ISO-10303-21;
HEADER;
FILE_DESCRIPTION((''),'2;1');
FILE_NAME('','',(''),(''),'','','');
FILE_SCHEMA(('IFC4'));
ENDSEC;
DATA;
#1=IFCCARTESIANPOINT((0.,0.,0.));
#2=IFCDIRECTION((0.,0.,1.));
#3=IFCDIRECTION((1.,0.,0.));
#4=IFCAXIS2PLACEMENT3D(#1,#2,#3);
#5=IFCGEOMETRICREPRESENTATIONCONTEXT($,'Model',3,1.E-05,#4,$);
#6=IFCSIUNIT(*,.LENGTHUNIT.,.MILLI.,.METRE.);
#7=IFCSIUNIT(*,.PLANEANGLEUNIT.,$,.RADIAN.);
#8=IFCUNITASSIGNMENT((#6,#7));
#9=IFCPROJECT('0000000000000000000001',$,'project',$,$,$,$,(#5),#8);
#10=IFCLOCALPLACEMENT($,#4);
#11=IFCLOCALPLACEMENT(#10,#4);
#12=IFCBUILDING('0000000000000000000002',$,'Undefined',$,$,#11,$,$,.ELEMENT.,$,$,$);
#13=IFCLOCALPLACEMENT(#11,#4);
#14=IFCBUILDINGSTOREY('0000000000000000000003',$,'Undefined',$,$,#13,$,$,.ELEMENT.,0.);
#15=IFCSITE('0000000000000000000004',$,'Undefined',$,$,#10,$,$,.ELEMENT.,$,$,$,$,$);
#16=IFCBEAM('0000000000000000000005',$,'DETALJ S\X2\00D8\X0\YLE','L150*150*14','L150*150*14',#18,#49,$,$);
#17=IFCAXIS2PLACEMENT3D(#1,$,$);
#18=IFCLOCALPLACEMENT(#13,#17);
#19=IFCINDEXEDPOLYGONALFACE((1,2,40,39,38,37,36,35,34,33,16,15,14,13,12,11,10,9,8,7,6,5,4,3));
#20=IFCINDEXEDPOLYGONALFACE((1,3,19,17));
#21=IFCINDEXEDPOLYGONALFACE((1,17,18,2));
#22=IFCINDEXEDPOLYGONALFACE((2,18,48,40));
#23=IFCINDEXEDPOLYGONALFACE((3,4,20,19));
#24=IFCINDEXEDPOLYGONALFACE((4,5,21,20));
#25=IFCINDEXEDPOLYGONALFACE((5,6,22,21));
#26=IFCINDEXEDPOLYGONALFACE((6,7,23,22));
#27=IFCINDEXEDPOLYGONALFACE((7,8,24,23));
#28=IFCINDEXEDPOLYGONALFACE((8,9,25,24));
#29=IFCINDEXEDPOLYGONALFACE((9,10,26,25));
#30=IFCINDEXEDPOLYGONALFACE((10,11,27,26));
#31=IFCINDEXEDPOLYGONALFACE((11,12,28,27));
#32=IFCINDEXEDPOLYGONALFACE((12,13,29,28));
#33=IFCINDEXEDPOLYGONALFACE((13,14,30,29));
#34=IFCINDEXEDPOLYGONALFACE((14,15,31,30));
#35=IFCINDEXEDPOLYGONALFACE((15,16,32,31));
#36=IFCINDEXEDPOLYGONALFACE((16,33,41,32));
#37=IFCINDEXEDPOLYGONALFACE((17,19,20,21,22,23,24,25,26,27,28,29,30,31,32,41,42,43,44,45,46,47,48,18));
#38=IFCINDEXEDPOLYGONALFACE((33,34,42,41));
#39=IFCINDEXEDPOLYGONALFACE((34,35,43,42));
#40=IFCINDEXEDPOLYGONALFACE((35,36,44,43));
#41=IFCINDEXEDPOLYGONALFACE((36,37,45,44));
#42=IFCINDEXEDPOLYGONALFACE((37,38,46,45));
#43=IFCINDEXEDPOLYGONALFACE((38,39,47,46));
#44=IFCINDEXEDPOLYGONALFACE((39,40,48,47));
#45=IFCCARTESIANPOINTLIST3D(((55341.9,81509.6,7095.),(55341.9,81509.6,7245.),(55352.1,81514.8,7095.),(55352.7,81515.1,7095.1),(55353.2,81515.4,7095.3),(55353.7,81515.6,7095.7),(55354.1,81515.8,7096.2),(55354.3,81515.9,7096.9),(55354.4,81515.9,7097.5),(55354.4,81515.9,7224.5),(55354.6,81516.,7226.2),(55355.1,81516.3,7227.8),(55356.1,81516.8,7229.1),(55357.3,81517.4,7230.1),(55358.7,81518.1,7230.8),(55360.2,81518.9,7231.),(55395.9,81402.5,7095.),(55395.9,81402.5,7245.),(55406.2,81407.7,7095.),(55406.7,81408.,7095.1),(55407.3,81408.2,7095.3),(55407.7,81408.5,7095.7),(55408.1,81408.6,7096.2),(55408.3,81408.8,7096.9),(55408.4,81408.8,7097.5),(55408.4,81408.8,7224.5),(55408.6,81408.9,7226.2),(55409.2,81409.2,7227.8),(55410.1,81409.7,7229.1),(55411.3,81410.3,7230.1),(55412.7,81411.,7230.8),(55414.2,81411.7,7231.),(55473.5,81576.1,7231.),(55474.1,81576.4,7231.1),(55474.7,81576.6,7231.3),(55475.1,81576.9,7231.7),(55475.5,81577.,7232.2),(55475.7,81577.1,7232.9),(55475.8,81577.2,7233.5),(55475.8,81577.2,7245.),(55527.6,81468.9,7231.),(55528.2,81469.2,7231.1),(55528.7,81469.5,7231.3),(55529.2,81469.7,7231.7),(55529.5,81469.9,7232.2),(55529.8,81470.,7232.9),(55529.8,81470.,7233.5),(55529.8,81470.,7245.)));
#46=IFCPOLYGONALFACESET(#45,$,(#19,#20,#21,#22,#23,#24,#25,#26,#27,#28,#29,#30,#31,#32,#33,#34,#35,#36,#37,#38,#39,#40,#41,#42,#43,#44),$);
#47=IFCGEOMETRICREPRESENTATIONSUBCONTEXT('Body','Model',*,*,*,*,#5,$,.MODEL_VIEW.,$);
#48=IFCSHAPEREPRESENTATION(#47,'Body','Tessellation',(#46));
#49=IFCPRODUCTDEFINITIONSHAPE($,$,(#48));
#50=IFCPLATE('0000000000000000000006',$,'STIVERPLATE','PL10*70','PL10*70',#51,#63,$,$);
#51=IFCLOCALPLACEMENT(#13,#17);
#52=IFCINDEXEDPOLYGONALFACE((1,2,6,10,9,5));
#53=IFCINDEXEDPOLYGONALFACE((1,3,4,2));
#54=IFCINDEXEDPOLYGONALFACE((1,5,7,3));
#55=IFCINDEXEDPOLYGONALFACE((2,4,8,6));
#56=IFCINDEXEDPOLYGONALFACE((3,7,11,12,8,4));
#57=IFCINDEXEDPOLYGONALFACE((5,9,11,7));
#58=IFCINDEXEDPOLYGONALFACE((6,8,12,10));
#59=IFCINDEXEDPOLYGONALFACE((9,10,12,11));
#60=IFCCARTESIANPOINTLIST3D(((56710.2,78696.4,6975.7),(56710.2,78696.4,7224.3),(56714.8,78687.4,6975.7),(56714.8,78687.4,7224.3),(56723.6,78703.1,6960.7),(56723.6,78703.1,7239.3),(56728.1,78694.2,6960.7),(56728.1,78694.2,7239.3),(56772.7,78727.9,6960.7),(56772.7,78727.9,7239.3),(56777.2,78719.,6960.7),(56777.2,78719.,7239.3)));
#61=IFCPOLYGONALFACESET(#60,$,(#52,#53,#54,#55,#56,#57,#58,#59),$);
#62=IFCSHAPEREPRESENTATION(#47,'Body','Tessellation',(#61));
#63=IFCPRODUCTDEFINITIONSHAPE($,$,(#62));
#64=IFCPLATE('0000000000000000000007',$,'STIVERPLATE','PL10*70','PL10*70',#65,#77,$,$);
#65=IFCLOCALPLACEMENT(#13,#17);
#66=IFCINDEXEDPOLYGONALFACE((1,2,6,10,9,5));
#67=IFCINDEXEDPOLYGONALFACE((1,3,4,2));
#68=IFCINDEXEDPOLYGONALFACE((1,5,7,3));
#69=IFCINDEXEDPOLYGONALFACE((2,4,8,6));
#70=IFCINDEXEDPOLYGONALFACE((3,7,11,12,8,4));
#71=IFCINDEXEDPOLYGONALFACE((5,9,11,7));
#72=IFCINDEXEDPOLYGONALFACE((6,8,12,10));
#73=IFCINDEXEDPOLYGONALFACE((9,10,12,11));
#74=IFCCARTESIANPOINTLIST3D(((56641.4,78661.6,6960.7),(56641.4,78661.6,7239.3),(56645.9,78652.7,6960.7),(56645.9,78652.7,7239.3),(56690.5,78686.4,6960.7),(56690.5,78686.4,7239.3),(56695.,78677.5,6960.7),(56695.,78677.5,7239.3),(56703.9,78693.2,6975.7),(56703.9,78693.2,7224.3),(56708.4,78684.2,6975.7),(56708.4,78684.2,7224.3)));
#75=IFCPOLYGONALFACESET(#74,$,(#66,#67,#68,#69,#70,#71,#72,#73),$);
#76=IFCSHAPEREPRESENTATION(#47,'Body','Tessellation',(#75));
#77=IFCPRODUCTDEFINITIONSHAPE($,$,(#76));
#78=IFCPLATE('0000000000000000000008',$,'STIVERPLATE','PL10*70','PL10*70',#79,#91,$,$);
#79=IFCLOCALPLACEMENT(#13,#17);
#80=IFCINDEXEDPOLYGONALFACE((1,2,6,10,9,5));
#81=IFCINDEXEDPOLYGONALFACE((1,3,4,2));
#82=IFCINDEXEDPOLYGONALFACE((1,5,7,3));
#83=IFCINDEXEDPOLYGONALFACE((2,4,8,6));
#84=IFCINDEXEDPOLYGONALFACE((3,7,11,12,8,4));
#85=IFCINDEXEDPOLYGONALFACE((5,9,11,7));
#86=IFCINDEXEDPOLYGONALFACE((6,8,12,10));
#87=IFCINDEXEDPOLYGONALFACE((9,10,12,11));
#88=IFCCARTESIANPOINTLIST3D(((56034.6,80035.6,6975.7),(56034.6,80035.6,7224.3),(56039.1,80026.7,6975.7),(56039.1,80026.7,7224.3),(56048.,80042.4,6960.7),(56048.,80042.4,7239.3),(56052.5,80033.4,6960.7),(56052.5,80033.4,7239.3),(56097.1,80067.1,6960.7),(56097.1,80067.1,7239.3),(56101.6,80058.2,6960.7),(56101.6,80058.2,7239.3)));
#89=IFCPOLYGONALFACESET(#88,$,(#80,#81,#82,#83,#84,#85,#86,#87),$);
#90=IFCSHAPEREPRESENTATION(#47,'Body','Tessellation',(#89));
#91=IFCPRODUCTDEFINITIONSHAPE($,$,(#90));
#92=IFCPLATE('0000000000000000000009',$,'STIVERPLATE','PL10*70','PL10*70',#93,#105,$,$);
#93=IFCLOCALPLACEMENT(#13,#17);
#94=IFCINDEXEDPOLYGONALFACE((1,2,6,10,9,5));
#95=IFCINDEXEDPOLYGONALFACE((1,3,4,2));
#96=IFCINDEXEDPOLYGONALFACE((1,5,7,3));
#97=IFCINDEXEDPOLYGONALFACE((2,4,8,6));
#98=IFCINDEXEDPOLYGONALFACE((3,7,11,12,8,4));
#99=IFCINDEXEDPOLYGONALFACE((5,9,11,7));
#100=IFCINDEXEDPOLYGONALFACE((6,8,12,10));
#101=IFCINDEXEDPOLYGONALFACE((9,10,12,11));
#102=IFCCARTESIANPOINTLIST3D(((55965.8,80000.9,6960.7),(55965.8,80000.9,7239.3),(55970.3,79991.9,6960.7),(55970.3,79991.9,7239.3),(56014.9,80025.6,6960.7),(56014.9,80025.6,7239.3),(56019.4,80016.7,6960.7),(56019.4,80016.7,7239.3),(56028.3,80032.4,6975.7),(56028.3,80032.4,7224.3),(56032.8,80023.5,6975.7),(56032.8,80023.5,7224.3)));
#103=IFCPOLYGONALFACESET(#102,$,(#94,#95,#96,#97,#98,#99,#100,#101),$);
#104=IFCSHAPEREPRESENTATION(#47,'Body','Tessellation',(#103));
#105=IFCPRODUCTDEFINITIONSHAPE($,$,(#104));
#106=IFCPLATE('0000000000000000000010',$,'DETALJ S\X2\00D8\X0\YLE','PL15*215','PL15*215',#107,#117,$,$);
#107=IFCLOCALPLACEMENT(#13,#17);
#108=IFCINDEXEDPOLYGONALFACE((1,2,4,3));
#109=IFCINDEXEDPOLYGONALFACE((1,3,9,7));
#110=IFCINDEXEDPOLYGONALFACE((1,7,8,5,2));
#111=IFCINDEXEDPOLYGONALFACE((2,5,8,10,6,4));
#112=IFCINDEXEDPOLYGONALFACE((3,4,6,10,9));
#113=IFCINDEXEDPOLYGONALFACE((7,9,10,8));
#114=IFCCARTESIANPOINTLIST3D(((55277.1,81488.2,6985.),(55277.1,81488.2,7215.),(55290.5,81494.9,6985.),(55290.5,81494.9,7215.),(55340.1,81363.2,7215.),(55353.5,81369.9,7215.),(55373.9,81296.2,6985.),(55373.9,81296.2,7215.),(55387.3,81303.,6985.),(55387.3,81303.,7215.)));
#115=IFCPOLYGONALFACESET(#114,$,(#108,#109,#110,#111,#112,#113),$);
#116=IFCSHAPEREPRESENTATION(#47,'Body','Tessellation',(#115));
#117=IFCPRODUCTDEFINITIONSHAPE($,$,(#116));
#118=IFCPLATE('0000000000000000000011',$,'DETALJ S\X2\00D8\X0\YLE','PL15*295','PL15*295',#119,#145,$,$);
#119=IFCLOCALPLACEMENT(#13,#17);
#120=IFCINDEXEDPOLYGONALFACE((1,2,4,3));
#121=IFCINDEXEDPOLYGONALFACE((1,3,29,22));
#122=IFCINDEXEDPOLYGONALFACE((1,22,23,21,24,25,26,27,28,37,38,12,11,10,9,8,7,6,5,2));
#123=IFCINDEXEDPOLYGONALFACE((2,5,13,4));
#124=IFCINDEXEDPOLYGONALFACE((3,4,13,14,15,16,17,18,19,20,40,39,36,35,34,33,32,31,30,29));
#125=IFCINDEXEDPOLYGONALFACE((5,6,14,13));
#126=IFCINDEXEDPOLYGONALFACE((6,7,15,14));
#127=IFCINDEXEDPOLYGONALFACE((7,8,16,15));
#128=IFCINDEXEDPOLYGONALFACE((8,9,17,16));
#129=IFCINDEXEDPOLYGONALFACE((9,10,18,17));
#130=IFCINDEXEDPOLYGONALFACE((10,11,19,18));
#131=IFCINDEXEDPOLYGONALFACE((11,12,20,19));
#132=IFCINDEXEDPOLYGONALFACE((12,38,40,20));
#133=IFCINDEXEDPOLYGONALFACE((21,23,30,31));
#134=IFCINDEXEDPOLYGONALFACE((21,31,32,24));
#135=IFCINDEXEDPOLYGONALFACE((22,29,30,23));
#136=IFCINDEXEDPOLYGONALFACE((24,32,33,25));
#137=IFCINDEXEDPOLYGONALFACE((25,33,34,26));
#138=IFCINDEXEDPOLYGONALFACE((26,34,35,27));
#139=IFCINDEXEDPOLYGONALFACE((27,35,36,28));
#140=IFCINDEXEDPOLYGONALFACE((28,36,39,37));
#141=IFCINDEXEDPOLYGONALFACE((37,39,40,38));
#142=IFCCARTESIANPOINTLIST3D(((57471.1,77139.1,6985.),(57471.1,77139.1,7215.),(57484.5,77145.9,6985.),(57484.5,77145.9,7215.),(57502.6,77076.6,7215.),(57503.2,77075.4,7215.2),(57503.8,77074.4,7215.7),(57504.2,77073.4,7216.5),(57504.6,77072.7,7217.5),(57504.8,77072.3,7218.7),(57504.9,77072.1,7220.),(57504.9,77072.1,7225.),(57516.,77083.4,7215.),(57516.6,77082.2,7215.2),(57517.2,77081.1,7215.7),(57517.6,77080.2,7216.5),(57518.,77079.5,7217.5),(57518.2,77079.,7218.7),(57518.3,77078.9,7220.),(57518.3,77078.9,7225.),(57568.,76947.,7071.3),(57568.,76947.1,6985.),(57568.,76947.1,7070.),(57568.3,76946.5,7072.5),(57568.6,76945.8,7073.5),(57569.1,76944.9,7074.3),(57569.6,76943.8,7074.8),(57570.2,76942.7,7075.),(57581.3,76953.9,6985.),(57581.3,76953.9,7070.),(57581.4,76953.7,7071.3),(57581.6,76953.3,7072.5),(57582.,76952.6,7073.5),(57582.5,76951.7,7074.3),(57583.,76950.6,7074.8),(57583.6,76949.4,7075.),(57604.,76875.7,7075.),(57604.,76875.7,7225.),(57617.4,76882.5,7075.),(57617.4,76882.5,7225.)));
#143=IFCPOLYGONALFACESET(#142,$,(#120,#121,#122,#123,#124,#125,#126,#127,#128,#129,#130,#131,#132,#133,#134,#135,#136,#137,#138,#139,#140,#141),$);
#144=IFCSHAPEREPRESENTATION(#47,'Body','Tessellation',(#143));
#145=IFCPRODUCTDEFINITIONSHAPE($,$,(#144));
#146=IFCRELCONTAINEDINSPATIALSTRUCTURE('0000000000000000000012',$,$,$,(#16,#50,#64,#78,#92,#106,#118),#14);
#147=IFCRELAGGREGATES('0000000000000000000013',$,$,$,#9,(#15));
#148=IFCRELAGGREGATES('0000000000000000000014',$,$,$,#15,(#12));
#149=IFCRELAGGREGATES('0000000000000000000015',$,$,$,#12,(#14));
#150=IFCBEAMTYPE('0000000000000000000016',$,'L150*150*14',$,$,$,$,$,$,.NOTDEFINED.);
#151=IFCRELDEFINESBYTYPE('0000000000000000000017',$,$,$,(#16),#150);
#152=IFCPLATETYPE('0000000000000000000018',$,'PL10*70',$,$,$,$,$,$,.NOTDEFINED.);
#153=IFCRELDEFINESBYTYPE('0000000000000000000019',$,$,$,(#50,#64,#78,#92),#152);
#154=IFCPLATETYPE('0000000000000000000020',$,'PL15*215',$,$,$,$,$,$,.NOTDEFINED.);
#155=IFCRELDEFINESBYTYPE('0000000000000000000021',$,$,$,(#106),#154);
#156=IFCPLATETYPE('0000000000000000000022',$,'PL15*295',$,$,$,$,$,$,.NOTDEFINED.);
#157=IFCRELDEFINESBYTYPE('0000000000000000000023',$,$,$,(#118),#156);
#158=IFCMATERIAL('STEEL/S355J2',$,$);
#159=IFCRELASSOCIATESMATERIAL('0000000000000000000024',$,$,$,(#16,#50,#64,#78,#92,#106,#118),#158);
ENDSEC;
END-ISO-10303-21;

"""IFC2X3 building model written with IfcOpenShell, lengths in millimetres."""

from ifc_helpers import new_model, si_unit, frame, frame_2d, origin_with_axes, origin_2d_with_axis, place, context, subcontext, project, spatial, polyline, circle_curve, parameter, trimmed, segment, composite_curve, l_section, outline, extrude, material, type_object, element, save


model = new_model("IFC2X3")

# Units and contexts
model_context = context("Model", 3, precision=1e-05, world=origin_with_axes())
body_context = subcontext(model_context, "Body", "Model", "MODEL_VIEW")
ifc_project = project(units=[si_unit("LENGTHUNIT", "METRE", prefix="MILLI"), si_unit("PLANEANGLEUNIT", "RADIAN")], contexts=[model_context])

# Site, building, storey
site_placement = place(None, origin_with_axes())
site = spatial("IfcSite", under=ifc_project, at=site_placement, Name="Undefined", CompositionType="ELEMENT")
building_placement = place(site_placement, origin_with_axes())
building = spatial("IfcBuilding", under=site, at=building_placement, Name="Undefined", CompositionType="ELEMENT")
storey_placement = place(building_placement, origin_with_axes())
storey = spatial("IfcBuildingStorey", under=building, at=storey_placement, Name="Undefined", CompositionType="ELEMENT", Elevation=0.0)

# Shared definitions
ifc_material_1 = material(Name="STEEL/S355J2")

# Beam
beam_type_1 = type_object("IfcBeamType", Name="L150*150*14", PredefinedType="NOTDEFINED")
for number, where, z_axis, x_axis, name in (
    (1, (55462.9, 81436.3, 7170.0), (0.892826, 0.450402, 0.0), (-0.450402, 0.892826, 0.0), "DETALJ SØYLE"),
):
    element("IfcBeam", number, at=place(storey_placement, frame(where, z_axis=z_axis, x_axis=x_axis)), inside=storey, type_object=beam_type_1, material=ifc_material_1, Name=name, Description="L150*150*14", ObjectType="L150*150*14", context=body_context, shape_type="SweptSolid", body=[
        extrude(l_section(Depth=150.0, Width=150.0, Thickness=14.0, FilletRadius=6.5, EdgeRadius=2.5, at=origin_2d_with_axis()), frame((120.0, 0.0, 0.0), z_axis=(-1.0, 0.0, 0.0), x_axis=(0.0, -1.0, 0.0)), (0.0, 0.0, 1.0), 120.0),
    ])

# Plates
plate_type_1 = type_object("IfcPlateType", Name="PL10*70", PredefinedType="NOTDEFINED")
plate_1_placement = place(storey_placement, frame((56775.0, 78723.4, 6960.7), z_axis=(-0.450412, 0.892821, 0.0), x_axis=(-0.892821, -0.450412, 0.0)))
element("IfcPlate", 2, at=plate_1_placement, inside=storey, type_object=plate_type_1, material=ifc_material_1, Name="STIVERPLATE", Description="PL10*70", ObjectType="PL10*70", context=body_context, shape_type="SweptSolid", body=[
    extrude(outline(polyline([(0.0, 0.0), (55.0, 0.0), (70.0, 15.0), (70.0, 263.6), (55.0, 278.6), (0.0, 278.6), (0.0, 0.0)])), frame((0.0, 0.0, -5.0), z_axis=(0.0, 0.0, 1.0), x_axis=(1.0, 0.0, 0.0)), (0.0, 0.0, 1.0), 10.0),
])
plate_2_placement = place(storey_placement, frame((56706.2, 78688.7, 6960.7), z_axis=(-0.450412, 0.892821, 0.0), x_axis=(-0.892821, -0.450412, 0.0)))
element("IfcPlate", 3, at=plate_2_placement, inside=storey, type_object=plate_type_1, material=ifc_material_1, Name="STIVERPLATE", Description="PL10*70", ObjectType="PL10*70", context=body_context, shape_type="SweptSolid", body=[
    extrude(outline(polyline([(0.0, 15.0), (15.0, 0.0), (70.0, 0.0), (70.0, 278.6), (15.0, 278.6), (0.0, 263.6), (0.0, 15.0)])), frame((0.0, 0.0, -5.0), z_axis=(0.0, 0.0, 1.0), x_axis=(1.0, 0.0, 0.0)), (0.0, 0.0, 1.0), 10.0),
])
plate_3_placement = place(storey_placement, frame((56099.4, 80062.7, 6960.7), z_axis=(-0.450412, 0.892821, 0.0), x_axis=(-0.892821, -0.450412, 0.0)))
element("IfcPlate", 4, at=plate_3_placement, inside=storey, type_object=plate_type_1, material=ifc_material_1, Name="STIVERPLATE", Description="PL10*70", ObjectType="PL10*70", context=body_context, shape_type="SweptSolid", body=[
    extrude(outline(polyline([(0.0, 0.0), (55.0, 0.0), (70.0, 15.0), (70.0, 263.6), (55.0, 278.6), (0.0, 278.6), (0.0, 0.0)])), frame((0.0, 0.0, -5.0), z_axis=(0.0, 0.0, 1.0), x_axis=(1.0, 0.0, 0.0)), (0.0, 0.0, 1.0), 10.0),
])
plate_4_placement = place(storey_placement, frame((56030.5, 80027.9, 6960.7), z_axis=(-0.450412, 0.892821, 0.0), x_axis=(-0.892821, -0.450412, 0.0)))
element("IfcPlate", 5, at=plate_4_placement, inside=storey, type_object=plate_type_1, material=ifc_material_1, Name="STIVERPLATE", Description="PL10*70", ObjectType="PL10*70", context=body_context, shape_type="SweptSolid", body=[
    extrude(outline(polyline([(0.0, 15.0), (15.0, 0.0), (70.0, 0.0), (70.0, 278.6), (15.0, 278.6), (0.0, 263.6), (0.0, 15.0)])), frame((0.0, 0.0, -5.0), z_axis=(0.0, 0.0, 1.0), x_axis=(1.0, 0.0, 0.0)), (0.0, 0.0, 1.0), 10.0),
])
plate_type_2 = type_object("IfcPlateType", Name="PL15*215", PredefinedType="NOTDEFINED")
plate_5_placement = place(storey_placement, frame((55346.8, 81366.5, 7215.0), z_axis=(-0.892821, -0.450412, 0.0), x_axis=(-0.450412, 0.892821, 0.0)))
element("IfcPlate", 6, at=plate_5_placement, inside=storey, type_object=plate_type_2, material=ifc_material_1, Name="DETALJ SØYLE", Description="PL15*215", ObjectType="PL15*215", context=body_context, shape_type="SweptSolid", body=[
    extrude(outline(polyline([(0.0, 0.0), (140.0, 0.0), (140.0, 230.0), (-75.0, 230.0), (-75.0, 0.0), (0.0, 0.0)])), frame((0.0, 0.0, -7.5), z_axis=(0.0, 0.0, 1.0), x_axis=(1.0, 0.0, 0.0)), (0.0, 0.0, 1.0), 15.0),
])
plate_type_3 = type_object("IfcPlateType", Name="PL15*295", PredefinedType="NOTDEFINED")
plate_6_placement = place(storey_placement, frame((57511.6, 77075.5, 7225.0), z_axis=(0.892821, 0.450412, 0.0), x_axis=(0.450412, -0.892821, 0.0)))
element("IfcPlate", 7, at=plate_6_placement, inside=storey, type_object=plate_type_3, material=ifc_material_1, Name="DETALJ SØYLE", Description="PL15*295", ObjectType="PL15*295", context=body_context, shape_type="SweptSolid", body=[
    extrude(outline(composite_curve([segment(polyline([(0.0, 0.0), (220.0, 0.0), (220.0, 150.0), (145.0, 150.0)]), True, "CONTINUOUS"), segment(trimmed(circle_curve(frame_2d((145.0, 155.0), x_axis=(0.0, -1.0)), 5.0), [parameter(0.0)], [parameter(4.712389)], False, "PARAMETER"), True, "CONTINUOUS"), segment(polyline([(140.0, 155.0), (140.0, 240.0), (-75.0, 240.0), (-75.0, 10.0), (-5.0, 10.0)]), True, "CONTINUOUS"), segment(trimmed(circle_curve(frame_2d((-5.0, 5.0), x_axis=(0.0, 1.0)), 5.0), [parameter(0.0)], [parameter(4.712389)], False, "PARAMETER"), True, "CONTINUOUS"), segment(polyline([(0.0, 5.0), (0.0, 0.0)]), True, "CONTINUOUS")], self_intersect=True)), frame((0.0, 0.0, -7.5), z_axis=(0.0, 0.0, 1.0), x_axis=(1.0, 0.0, 0.0)), (0.0, 0.0, 1.0), 15.0),
])

save(model, "model.ifc")
